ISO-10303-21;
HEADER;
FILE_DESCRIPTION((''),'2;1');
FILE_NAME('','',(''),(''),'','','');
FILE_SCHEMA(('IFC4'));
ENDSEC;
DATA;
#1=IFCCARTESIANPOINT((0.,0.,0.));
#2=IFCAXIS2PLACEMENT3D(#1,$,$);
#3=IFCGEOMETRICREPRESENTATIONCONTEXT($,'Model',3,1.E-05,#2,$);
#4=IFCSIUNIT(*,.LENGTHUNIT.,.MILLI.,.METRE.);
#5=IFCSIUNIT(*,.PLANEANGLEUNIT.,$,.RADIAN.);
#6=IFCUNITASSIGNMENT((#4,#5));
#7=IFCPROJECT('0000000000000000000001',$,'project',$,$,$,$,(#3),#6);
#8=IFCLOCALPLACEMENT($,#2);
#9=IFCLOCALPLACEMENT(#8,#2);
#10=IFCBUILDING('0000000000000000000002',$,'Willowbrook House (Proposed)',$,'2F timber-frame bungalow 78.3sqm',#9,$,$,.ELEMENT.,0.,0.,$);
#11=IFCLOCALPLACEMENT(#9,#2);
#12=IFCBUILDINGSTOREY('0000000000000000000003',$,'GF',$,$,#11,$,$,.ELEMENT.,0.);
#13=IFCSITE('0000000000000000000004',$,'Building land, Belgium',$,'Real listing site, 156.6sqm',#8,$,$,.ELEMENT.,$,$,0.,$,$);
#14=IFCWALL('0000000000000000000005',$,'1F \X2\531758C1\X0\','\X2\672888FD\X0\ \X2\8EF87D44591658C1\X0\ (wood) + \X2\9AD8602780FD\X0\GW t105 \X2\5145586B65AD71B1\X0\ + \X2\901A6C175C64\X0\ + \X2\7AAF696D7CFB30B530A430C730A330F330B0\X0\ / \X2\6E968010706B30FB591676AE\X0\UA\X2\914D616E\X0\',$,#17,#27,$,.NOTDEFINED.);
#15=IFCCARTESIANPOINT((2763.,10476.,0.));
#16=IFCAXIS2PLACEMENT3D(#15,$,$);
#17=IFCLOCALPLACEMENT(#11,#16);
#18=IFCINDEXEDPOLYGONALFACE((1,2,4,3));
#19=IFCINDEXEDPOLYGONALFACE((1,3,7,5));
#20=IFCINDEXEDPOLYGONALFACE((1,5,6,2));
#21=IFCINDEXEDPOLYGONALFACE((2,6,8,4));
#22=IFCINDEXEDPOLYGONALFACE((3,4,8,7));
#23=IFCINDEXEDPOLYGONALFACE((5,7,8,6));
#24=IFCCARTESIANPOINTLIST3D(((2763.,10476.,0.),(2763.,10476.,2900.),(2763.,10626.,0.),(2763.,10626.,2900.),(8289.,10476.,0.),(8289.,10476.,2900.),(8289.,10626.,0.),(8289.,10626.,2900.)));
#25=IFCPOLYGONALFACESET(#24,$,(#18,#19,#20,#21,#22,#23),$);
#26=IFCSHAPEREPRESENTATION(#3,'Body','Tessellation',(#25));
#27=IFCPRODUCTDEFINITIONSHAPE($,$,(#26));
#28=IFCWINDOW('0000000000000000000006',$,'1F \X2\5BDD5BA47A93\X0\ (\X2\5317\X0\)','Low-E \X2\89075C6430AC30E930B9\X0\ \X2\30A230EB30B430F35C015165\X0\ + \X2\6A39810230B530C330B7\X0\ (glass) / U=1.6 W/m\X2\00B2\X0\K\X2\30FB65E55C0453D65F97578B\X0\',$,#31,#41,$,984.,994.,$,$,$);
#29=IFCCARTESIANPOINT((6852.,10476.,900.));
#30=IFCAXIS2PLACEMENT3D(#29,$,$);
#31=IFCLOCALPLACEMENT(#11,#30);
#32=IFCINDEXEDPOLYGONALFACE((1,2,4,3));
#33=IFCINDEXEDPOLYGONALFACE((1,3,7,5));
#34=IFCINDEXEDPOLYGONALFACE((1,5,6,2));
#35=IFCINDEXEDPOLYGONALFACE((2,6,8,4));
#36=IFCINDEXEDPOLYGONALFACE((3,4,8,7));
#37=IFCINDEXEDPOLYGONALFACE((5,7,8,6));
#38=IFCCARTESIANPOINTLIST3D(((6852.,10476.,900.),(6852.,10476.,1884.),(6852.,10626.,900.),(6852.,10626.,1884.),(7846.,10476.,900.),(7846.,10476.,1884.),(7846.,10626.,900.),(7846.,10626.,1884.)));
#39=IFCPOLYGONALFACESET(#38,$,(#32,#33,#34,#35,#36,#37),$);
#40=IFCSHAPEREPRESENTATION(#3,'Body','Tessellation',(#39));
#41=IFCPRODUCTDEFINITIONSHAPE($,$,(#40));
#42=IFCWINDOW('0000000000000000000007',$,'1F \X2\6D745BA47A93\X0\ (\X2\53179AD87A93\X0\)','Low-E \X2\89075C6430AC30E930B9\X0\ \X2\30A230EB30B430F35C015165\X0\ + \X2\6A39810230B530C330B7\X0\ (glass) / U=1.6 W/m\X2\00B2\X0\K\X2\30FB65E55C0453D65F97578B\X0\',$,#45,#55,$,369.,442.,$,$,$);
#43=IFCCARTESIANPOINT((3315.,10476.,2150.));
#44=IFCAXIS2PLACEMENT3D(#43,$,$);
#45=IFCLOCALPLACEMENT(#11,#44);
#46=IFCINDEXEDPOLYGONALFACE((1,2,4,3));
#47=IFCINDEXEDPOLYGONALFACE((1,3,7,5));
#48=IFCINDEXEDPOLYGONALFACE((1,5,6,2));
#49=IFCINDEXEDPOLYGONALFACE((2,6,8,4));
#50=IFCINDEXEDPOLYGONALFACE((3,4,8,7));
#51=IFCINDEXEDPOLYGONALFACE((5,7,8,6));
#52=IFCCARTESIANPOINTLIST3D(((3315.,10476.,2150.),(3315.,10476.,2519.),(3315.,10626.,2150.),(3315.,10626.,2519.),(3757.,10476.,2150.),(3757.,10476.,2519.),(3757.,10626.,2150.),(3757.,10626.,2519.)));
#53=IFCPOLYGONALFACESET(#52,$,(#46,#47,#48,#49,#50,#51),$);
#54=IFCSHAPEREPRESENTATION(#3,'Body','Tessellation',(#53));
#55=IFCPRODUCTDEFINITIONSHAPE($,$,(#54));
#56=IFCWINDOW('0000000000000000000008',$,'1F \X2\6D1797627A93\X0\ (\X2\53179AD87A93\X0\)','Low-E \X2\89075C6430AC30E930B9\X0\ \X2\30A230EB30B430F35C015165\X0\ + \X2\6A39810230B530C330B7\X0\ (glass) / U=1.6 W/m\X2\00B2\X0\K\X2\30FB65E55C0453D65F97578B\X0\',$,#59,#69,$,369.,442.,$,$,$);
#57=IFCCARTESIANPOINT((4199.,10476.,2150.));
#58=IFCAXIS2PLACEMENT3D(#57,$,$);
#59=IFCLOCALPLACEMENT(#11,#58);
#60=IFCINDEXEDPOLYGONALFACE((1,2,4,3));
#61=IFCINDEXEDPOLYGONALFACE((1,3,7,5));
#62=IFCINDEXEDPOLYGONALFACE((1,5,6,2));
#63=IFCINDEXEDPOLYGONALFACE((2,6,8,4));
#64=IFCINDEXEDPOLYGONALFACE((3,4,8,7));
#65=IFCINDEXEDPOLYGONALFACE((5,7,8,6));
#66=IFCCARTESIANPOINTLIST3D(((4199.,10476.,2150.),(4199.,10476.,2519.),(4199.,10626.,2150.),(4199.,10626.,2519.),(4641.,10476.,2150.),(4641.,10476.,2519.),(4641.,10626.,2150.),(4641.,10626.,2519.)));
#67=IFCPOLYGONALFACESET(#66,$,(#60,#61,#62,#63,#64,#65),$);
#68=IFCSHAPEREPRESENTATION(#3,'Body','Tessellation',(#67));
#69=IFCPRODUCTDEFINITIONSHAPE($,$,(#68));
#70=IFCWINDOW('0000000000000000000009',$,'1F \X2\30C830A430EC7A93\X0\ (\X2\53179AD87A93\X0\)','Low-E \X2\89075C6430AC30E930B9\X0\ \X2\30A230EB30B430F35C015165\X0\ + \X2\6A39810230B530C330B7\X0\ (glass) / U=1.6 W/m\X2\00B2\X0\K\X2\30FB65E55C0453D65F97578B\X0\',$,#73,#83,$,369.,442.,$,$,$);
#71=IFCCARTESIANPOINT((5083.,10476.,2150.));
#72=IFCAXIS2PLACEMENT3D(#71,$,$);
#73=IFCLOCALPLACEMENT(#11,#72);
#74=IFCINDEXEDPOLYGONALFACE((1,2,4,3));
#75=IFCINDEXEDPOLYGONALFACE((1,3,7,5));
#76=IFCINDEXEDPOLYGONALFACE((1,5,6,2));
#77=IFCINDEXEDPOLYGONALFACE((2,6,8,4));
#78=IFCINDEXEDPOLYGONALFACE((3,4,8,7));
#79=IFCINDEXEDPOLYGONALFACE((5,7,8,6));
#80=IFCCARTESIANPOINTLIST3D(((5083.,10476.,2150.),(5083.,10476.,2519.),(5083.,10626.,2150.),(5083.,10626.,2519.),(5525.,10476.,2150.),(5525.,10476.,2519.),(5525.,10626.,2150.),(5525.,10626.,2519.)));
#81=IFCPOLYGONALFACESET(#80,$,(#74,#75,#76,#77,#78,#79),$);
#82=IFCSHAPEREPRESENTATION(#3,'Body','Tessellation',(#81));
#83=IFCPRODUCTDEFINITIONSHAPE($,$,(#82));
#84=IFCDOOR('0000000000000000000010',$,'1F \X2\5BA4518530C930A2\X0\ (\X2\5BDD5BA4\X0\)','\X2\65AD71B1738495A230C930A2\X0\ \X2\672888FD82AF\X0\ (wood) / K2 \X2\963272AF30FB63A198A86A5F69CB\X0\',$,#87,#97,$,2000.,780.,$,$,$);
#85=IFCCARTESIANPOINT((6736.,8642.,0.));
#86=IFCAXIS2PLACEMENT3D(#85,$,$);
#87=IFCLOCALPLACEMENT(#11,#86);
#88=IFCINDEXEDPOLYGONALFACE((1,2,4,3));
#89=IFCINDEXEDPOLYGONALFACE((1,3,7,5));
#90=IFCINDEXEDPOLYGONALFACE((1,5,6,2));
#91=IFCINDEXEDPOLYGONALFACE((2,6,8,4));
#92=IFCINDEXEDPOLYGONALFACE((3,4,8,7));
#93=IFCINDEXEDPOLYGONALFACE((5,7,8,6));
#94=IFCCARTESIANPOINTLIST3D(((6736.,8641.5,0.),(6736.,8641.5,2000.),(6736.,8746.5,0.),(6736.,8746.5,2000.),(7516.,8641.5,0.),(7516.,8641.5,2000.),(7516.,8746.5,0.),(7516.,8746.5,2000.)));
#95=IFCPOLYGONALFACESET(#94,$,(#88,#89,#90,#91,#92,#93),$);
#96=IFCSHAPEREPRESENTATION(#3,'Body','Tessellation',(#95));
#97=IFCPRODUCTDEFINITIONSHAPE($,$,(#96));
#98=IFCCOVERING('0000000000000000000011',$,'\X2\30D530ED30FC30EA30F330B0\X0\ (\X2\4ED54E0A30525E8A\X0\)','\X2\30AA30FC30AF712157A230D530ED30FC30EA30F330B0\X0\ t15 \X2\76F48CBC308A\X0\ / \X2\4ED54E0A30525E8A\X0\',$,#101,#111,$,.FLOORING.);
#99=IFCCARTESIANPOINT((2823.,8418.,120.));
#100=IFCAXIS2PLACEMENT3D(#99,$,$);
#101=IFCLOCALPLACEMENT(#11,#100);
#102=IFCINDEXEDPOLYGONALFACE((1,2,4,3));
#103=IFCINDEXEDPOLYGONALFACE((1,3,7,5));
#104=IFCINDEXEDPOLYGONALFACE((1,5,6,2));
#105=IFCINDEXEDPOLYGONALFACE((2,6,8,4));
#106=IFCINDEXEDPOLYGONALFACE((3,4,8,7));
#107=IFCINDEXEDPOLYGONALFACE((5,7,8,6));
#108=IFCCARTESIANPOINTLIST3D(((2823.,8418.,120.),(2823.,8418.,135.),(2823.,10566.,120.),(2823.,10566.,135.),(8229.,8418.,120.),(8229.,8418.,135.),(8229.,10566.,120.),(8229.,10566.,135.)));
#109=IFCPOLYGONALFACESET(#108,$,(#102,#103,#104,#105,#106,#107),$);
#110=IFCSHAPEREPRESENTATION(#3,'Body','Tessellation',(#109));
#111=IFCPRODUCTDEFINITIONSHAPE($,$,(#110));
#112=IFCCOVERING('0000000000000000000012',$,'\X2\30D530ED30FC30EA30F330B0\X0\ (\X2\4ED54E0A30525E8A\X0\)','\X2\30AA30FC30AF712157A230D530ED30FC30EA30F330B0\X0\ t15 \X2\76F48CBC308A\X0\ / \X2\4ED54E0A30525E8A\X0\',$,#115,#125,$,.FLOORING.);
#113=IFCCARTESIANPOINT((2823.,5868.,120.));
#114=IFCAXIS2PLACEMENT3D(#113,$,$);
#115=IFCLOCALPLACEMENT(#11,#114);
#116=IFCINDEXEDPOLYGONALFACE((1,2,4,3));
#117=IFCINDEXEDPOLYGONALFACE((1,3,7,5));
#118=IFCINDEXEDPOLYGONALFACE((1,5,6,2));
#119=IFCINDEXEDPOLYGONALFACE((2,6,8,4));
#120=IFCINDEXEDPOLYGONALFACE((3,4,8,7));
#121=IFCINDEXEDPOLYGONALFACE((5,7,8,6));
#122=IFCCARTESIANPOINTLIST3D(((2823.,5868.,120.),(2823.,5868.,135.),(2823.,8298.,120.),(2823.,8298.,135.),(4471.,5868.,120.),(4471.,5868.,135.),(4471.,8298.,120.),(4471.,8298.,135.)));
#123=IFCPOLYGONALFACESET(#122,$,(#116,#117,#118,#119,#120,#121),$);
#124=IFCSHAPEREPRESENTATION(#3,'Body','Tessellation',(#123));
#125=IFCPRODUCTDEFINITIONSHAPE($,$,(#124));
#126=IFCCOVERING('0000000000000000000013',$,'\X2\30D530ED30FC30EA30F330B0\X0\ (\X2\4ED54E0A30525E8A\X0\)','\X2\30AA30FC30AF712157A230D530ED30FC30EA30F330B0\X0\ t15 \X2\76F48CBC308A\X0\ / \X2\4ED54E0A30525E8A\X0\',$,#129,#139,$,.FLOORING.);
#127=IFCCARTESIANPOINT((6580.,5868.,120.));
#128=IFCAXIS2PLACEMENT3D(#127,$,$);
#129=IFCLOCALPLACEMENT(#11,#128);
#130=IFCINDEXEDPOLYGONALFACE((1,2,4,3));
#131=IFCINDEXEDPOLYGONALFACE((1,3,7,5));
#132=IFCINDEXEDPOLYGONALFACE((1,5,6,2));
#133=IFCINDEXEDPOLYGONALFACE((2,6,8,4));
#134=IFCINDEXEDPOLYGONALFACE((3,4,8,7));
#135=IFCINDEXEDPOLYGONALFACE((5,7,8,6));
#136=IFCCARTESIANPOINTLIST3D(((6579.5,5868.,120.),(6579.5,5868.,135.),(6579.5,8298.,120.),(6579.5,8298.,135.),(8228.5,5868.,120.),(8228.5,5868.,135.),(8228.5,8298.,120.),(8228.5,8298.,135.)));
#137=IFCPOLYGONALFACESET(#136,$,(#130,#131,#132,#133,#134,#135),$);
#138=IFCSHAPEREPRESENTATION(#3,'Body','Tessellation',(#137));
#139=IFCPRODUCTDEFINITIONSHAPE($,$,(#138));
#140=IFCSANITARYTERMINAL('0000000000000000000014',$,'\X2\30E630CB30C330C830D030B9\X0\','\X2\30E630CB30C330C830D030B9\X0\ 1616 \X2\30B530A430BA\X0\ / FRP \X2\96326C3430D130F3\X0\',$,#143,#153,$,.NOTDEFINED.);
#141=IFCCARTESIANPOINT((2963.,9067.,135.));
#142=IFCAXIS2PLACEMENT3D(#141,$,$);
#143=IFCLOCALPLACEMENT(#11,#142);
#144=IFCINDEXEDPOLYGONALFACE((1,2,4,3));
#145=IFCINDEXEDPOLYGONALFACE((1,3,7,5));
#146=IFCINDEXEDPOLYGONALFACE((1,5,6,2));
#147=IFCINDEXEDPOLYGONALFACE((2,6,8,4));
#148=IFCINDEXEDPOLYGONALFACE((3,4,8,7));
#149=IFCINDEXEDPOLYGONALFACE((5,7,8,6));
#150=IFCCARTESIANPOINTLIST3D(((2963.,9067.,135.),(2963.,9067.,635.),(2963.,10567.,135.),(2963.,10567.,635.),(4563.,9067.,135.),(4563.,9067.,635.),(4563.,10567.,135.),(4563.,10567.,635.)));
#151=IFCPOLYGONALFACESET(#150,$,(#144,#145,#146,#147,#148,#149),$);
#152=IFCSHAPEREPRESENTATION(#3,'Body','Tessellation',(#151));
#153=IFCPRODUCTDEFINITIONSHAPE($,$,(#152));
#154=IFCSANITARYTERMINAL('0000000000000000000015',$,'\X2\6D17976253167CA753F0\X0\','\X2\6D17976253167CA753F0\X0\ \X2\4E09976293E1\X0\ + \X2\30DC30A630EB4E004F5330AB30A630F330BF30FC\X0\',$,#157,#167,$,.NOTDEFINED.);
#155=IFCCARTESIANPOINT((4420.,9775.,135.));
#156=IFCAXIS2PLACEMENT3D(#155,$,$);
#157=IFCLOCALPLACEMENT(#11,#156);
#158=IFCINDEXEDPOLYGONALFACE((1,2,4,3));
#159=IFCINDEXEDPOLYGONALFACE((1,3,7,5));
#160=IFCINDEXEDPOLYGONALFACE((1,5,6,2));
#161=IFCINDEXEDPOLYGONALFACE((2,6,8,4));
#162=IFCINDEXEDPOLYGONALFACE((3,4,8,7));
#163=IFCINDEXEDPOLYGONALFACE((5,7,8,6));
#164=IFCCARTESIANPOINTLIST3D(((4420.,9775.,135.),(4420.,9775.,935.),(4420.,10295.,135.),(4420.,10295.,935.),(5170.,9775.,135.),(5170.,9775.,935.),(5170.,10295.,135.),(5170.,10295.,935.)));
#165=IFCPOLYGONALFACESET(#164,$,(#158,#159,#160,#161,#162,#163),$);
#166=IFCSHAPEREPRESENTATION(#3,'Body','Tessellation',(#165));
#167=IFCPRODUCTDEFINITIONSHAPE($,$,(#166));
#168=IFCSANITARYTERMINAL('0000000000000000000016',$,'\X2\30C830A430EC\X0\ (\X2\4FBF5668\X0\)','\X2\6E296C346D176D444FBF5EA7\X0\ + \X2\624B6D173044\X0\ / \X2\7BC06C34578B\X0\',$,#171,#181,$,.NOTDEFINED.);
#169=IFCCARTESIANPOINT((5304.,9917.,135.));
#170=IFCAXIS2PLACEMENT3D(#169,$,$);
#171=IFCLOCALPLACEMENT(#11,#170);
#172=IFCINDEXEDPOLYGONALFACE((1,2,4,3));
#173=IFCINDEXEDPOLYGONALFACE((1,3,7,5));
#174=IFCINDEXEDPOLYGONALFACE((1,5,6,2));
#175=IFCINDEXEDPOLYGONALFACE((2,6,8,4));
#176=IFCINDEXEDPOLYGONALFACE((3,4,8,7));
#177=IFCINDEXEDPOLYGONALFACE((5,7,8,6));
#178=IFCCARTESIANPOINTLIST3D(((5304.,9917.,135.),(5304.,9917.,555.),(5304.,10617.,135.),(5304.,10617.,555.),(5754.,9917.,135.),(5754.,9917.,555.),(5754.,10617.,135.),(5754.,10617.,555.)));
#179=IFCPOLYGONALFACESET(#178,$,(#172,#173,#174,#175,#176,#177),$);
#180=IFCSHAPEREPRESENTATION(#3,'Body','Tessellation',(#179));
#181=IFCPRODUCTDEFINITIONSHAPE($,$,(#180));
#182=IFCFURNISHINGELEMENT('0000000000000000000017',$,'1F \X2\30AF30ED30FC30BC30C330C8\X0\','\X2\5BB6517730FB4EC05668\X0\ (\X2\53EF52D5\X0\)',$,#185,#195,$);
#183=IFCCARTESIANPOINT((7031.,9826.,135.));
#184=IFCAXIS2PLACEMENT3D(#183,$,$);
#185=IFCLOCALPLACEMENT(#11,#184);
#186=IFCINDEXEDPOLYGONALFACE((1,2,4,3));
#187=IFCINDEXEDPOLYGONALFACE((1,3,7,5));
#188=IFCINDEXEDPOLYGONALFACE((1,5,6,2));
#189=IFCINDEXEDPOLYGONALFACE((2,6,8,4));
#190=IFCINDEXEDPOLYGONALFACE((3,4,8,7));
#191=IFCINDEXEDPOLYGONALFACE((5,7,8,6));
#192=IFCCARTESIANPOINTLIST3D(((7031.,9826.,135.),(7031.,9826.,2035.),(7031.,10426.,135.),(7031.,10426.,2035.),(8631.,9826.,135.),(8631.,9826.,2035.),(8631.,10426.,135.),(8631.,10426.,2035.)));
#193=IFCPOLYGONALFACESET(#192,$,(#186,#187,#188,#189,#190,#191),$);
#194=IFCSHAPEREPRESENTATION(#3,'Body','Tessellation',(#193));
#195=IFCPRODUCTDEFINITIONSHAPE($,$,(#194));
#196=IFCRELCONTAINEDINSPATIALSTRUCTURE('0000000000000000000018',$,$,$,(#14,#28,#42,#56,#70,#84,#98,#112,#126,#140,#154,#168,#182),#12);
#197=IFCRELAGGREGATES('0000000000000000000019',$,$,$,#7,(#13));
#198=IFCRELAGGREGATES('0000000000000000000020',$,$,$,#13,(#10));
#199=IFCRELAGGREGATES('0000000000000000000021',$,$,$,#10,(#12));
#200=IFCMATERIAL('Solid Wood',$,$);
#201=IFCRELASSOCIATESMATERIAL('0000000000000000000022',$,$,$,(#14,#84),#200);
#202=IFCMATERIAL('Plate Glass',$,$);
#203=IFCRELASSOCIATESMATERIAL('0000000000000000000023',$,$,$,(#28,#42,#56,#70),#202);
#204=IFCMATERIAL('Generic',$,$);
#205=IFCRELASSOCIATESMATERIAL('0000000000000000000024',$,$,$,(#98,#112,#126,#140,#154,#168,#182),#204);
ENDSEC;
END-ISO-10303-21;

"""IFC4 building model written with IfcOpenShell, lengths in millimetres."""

from ifc_helpers import new_model, si_unit, frame, frame_2d, origin, place, context, project, spatial, rectangle, extrude, material, element, fill, save


model = new_model("IFC4")

# Units and contexts
model_context = context("Model", 3, precision=1e-05, world=origin())
ifc_project = project(units=[si_unit("LENGTHUNIT", "METRE", prefix="MILLI"), si_unit("PLANEANGLEUNIT", "RADIAN")], contexts=[model_context])

# Site, building, storey
site_placement = place(None, origin())
site = spatial("IfcSite", under=ifc_project, at=site_placement, Name="Building land, Belgium", ObjectType="Real listing site, 156.6sqm", CompositionType="ELEMENT", RefElevation=0.0)
building_placement = place(site_placement, origin())
building = spatial("IfcBuilding", under=site, at=building_placement, Name="Willowbrook House (Proposed)", ObjectType="2F timber-frame bungalow 78.3sqm", CompositionType="ELEMENT", ElevationOfRefHeight=0.0, ElevationOfTerrain=0.0)
storey_placement = place(building_placement, origin())
storey = spatial("IfcBuildingStorey", under=building, at=storey_placement, Name="GF", CompositionType="ELEMENT", Elevation=0.0)

# Shared definitions
ifc_material_1 = material(Name="Solid Wood")

# Wall, openings, windows
wall_1_placement = place(storey_placement, frame((2763.0, 10476.0, 0.0)))
wall_1 = element("IfcWall", 1, at=wall_1_placement, inside=storey, material=ifc_material_1, Name="1F 北壁", Description="木製 軸組外壁 (wood) + 高性能GW t105 充填断熱 + 通気層 + 窯業系サイディング / 準耐火・外皮UA配慮", PredefinedType="NOTDEFINED", context=model_context, shape_type="SweptSolid", body=[
    extrude(rectangle(XDim=5526.0, YDim=150.0, at=frame_2d((2763.0, 75.0))), frame((2763.0, 10476.0, 0.0)), (0.0, 0.0, 1.0), 2900.0),
])
opening_1_placement = place(storey_placement, frame((6852.0, 10476.0, 900.0)))
opening_1 = element("IfcOpeningElement", 2, at=opening_1_placement, cuts=wall_1, PredefinedType="NOTDEFINED", context=model_context, shape_type="SweptSolid", body=[
    extrude(rectangle(XDim=994.0, YDim=150.0, at=frame_2d((497.0, 75.0))), frame((6852.0, 10476.0, 900.0)), (0.0, 0.0, 1.0), 984.0),
])
opening_2_placement = place(storey_placement, frame((3315.0, 10476.0, 2150.0)))
opening_2 = element("IfcOpeningElement", 3, at=opening_2_placement, cuts=wall_1, PredefinedType="NOTDEFINED", context=model_context, shape_type="SweptSolid", body=[
    extrude(rectangle(XDim=442.0, YDim=150.0, at=frame_2d((221.0, 75.0))), frame((3315.0, 10476.0, 2150.0)), (0.0, 0.0, 1.0), 369.0),
])
opening_3_placement = place(storey_placement, frame((4199.0, 10476.0, 2150.0)))
opening_3 = element("IfcOpeningElement", 4, at=opening_3_placement, cuts=wall_1, PredefinedType="NOTDEFINED", context=model_context, shape_type="SweptSolid", body=[
    extrude(rectangle(XDim=442.0, YDim=150.0, at=frame_2d((221.0, 75.0))), frame((4199.0, 10476.0, 2150.0)), (0.0, 0.0, 1.0), 369.0),
])
opening_4_placement = place(storey_placement, frame((5083.0, 10476.0, 2150.0)))
opening_4 = element("IfcOpeningElement", 5, at=opening_4_placement, cuts=wall_1, PredefinedType="NOTDEFINED", context=model_context, shape_type="SweptSolid", body=[
    extrude(rectangle(XDim=442.0, YDim=150.0, at=frame_2d((221.0, 75.0))), frame((5083.0, 10476.0, 2150.0)), (0.0, 0.0, 1.0), 369.0),
])
ifc_material_2 = material(Name="Plate Glass")
window_1_placement = place(storey_placement, frame((6852.0, 10476.0, 900.0)))
window_1 = element("IfcWindow", 6, at=window_1_placement, inside=storey, material=ifc_material_2, Name="1F 寝室窓 (北)", Description="Low-E 複層ガラス アルゴン封入 + 樹脂サッシ (glass) / U=1.6 W/m²K・日射取得型", OverallHeight=984.0, OverallWidth=994.0, context=model_context, shape_type="SweptSolid", body=[
    extrude(rectangle(XDim=994.0, YDim=150.0, at=frame_2d((497.0, 75.0))), frame((6852.0, 10476.0, 900.0)), (0.0, 0.0, 1.0), 984.0),
])
fill(opening_1, window_1)
window_2_placement = place(storey_placement, frame((3315.0, 10476.0, 2150.0)))
window_2 = element("IfcWindow", 7, at=window_2_placement, inside=storey, material=ifc_material_2, Name="1F 浴室窓 (北高窓)", Description="Low-E 複層ガラス アルゴン封入 + 樹脂サッシ (glass) / U=1.6 W/m²K・日射取得型", OverallHeight=369.0, OverallWidth=442.0, context=model_context, shape_type="SweptSolid", body=[
    extrude(rectangle(XDim=442.0, YDim=150.0, at=frame_2d((221.0, 75.0))), frame((3315.0, 10476.0, 2150.0)), (0.0, 0.0, 1.0), 369.0),
])
fill(opening_2, window_2)
window_3_placement = place(storey_placement, frame((4199.0, 10476.0, 2150.0)))
window_3 = element("IfcWindow", 8, at=window_3_placement, inside=storey, material=ifc_material_2, Name="1F 洗面窓 (北高窓)", Description="Low-E 複層ガラス アルゴン封入 + 樹脂サッシ (glass) / U=1.6 W/m²K・日射取得型", OverallHeight=369.0, OverallWidth=442.0, context=model_context, shape_type="SweptSolid", body=[
    extrude(rectangle(XDim=442.0, YDim=150.0, at=frame_2d((221.0, 75.0))), frame((4199.0, 10476.0, 2150.0)), (0.0, 0.0, 1.0), 369.0),
])
fill(opening_3, window_3)
window_4_placement = place(storey_placement, frame((5083.0, 10476.0, 2150.0)))
window_4 = element("IfcWindow", 9, at=window_4_placement, inside=storey, material=ifc_material_2, Name="1F トイレ窓 (北高窓)", Description="Low-E 複層ガラス アルゴン封入 + 樹脂サッシ (glass) / U=1.6 W/m²K・日射取得型", OverallHeight=369.0, OverallWidth=442.0, context=model_context, shape_type="SweptSolid", body=[
    extrude(rectangle(XDim=442.0, YDim=150.0, at=frame_2d((221.0, 75.0))), frame((5083.0, 10476.0, 2150.0)), (0.0, 0.0, 1.0), 369.0),
])
fill(opening_4, window_4)

# Door
door_1_placement = place(storey_placement, frame((6736.0, 8642.0, 0.0)))
element("IfcDoor", 10, at=door_1_placement, inside=storey, material=ifc_material_1, Name="1F 室内ドア (寝室)", Description="断熱玄関ドア 木製芯 (wood) / K2 防犯・採風機構", OverallHeight=2000.0, OverallWidth=780.0, context=model_context, shape_type="SweptSolid", body=[
    extrude(rectangle(XDim=780.0, YDim=105.0, at=frame_2d((390.0, 52.0))), frame((6736.0, 8642.0, 0.0)), (0.0, 0.0, 1.0), 2000.0),
])

# Coverings
ifc_material_3 = material(Name="Generic")
covering_1_placement = place(storey_placement, frame((2823.0, 8418.0, 120.0)))
element("IfcCovering", 11, at=covering_1_placement, inside=storey, material=ifc_material_3, Name="フローリング (仕上げ床)", Description="オーク無垢フローリング t15 直貼り / 仕上げ床", PredefinedType="FLOORING", context=model_context, shape_type="SweptSolid", body=[
    extrude(rectangle(XDim=5406.0, YDim=2148.0, at=frame_2d((2703.0, 1074.0))), frame((2823.0, 8418.0, 120.0)), (0.0, 0.0, 1.0), 15.0),
])
covering_2_placement = place(storey_placement, frame((2823.0, 5868.0, 120.0)))
element("IfcCovering", 12, at=covering_2_placement, inside=storey, material=ifc_material_3, Name="フローリング (仕上げ床)", Description="オーク無垢フローリング t15 直貼り / 仕上げ床", PredefinedType="FLOORING", context=model_context, shape_type="SweptSolid", body=[
    extrude(rectangle(XDim=1648.0, YDim=2430.0, at=frame_2d((824.0, 1215.0))), frame((2823.0, 5868.0, 120.0)), (0.0, 0.0, 1.0), 15.0),
])
covering_3_placement = place(storey_placement, frame((6580.0, 5868.0, 120.0)))
element("IfcCovering", 13, at=covering_3_placement, inside=storey, material=ifc_material_3, Name="フローリング (仕上げ床)", Description="オーク無垢フローリング t15 直貼り / 仕上げ床", PredefinedType="FLOORING", context=model_context, shape_type="SweptSolid", body=[
    extrude(rectangle(XDim=1649.0, YDim=2430.0, at=frame_2d((824.0, 1215.0))), frame((6580.0, 5868.0, 120.0)), (0.0, 0.0, 1.0), 15.0),
])

# Sanitary terminals
sanitary_terminal_1_placement = place(storey_placement, frame((2963.0, 9067.0, 135.0)))
element("IfcSanitaryTerminal", 14, at=sanitary_terminal_1_placement, inside=storey, material=ifc_material_3, Name="ユニットバス", Description="ユニットバス 1616 サイズ / FRP 防水パン", PredefinedType="NOTDEFINED", context=model_context, shape_type="SweptSolid", body=[
    extrude(rectangle(XDim=1600.0, YDim=1500.0, at=frame_2d((800.0, 750.0))), frame((2963.0, 9067.0, 135.0)), (0.0, 0.0, 1.0), 500.0),
])
sanitary_terminal_2_placement = place(storey_placement, frame((4420.0, 9775.0, 135.0)))
element("IfcSanitaryTerminal", 15, at=sanitary_terminal_2_placement, inside=storey, material=ifc_material_3, Name="洗面化粧台", Description="洗面化粧台 三面鏡 + ボウル一体カウンター", PredefinedType="NOTDEFINED", context=model_context, shape_type="SweptSolid", body=[
    extrude(rectangle(XDim=750.0, YDim=520.0, at=frame_2d((375.0, 260.0))), frame((4420.0, 9775.0, 135.0)), (0.0, 0.0, 1.0), 800.0),
])
sanitary_terminal_3_placement = place(storey_placement, frame((5304.0, 9917.0, 135.0)))
element("IfcSanitaryTerminal", 16, at=sanitary_terminal_3_placement, inside=storey, material=ifc_material_3, Name="トイレ (便器)", Description="温水洗浄便座 + 手洗い / 節水型", PredefinedType="NOTDEFINED", context=model_context, shape_type="SweptSolid", body=[
    extrude(rectangle(XDim=450.0, YDim=700.0, at=frame_2d((225.0, 350.0))), frame((5304.0, 9917.0, 135.0)), (0.0, 0.0, 1.0), 420.0),
])

# Furnishing element
furnishing_placement = place(storey_placement, frame((7031.0, 9826.0, 135.0)))
element("IfcFurnishingElement", 17, at=furnishing_placement, inside=storey, material=ifc_material_3, Name="1F クローゼット", Description="家具・什器 (可動)", context=model_context, shape_type="SweptSolid", body=[
    extrude(rectangle(XDim=1600.0, YDim=600.0, at=frame_2d((800.0, 300.0))), frame((7031.0, 9826.0, 135.0)), (0.0, 0.0, 1.0), 1900.0),
])

save(model, "model.ifc")
